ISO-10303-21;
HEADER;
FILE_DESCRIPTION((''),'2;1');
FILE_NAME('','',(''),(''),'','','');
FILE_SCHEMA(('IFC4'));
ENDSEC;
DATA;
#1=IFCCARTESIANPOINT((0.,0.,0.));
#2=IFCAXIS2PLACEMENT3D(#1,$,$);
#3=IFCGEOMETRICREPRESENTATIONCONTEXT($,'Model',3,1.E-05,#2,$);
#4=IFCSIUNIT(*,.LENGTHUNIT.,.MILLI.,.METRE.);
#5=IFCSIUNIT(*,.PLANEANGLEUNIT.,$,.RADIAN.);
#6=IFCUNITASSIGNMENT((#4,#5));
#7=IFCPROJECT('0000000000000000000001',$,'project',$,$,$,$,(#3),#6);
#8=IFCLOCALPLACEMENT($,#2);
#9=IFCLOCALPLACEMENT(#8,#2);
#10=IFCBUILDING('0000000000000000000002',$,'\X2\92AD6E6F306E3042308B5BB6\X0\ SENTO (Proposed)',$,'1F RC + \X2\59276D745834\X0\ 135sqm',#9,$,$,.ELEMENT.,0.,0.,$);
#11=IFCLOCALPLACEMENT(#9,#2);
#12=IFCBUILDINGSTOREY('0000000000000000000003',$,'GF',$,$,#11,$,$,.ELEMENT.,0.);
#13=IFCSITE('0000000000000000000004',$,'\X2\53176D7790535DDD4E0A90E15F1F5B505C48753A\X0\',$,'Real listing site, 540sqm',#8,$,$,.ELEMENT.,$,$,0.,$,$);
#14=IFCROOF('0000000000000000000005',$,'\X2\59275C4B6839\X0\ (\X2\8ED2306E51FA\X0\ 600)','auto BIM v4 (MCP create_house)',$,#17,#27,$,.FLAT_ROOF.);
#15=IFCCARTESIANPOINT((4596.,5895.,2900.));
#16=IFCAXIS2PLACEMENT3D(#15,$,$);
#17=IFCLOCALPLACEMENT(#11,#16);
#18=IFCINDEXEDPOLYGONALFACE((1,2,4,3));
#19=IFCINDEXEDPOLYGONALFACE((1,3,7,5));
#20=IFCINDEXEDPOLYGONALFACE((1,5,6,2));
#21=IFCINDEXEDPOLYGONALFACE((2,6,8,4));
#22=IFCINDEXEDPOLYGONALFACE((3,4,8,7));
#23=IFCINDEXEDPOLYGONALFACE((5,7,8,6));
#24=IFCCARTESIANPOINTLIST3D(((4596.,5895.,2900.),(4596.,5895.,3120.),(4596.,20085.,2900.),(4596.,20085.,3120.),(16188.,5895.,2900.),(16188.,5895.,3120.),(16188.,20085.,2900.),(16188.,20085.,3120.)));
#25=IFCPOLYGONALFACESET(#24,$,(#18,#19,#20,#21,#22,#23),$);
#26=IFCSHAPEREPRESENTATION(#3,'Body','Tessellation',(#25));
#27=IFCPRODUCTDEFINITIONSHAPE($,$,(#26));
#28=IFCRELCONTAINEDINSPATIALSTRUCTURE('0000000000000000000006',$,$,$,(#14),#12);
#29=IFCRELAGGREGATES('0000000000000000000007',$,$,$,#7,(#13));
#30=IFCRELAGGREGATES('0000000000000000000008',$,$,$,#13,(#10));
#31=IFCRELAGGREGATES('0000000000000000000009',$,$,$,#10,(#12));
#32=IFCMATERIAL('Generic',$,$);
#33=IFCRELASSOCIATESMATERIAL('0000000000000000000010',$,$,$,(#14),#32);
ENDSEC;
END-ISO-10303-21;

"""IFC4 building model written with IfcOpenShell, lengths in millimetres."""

from ifc_helpers import new_model, si_unit, frame, frame_2d, origin, place, context, project, spatial, rectangle, extrude, material, element, save


model = new_model("IFC4")

# Units and contexts
model_context = context("Model", 3, precision=1e-05, world=origin())
ifc_project = project(units=[si_unit("LENGTHUNIT", "METRE", prefix="MILLI"), si_unit("PLANEANGLEUNIT", "RADIAN")], contexts=[model_context])

# Site, building, storey
site_placement = place(None, origin())
site = spatial("IfcSite", under=ifc_project, at=site_placement, Name="北海道川上郡弟子屈町", ObjectType="Real listing site, 540sqm", CompositionType="ELEMENT", RefElevation=0.0)
building_placement = place(site_placement, origin())
building = spatial("IfcBuilding", under=site, at=building_placement, Name="銭湯のある家 SENTO (Proposed)", ObjectType="1F RC + 大浴場 135sqm", CompositionType="ELEMENT", ElevationOfRefHeight=0.0, ElevationOfTerrain=0.0)
storey_placement = place(building_placement, origin())
storey = spatial("IfcBuildingStorey", under=building, at=storey_placement, Name="GF", CompositionType="ELEMENT", Elevation=0.0)

# Shared definitions
ifc_material = material(Name="Generic")

# Roof
roof_placement = place(storey_placement, frame((4596.0, 5895.0, 2900.0)))
element("IfcRoof", 1, at=roof_placement, inside=storey, material=ifc_material, Name="大屋根 (軒の出 600)", Description="auto BIM v4 (MCP create_house)", PredefinedType="FLAT_ROOF", context=model_context, shape_type="SweptSolid", body=[
    extrude(rectangle(XDim=11592.0, YDim=14190.0, at=frame_2d((5796.0, 7095.0))), frame((4596.0, 5895.0, 2900.0)), (0.0, 0.0, 1.0), 220.0),
])

save(model, "model.ifc")
